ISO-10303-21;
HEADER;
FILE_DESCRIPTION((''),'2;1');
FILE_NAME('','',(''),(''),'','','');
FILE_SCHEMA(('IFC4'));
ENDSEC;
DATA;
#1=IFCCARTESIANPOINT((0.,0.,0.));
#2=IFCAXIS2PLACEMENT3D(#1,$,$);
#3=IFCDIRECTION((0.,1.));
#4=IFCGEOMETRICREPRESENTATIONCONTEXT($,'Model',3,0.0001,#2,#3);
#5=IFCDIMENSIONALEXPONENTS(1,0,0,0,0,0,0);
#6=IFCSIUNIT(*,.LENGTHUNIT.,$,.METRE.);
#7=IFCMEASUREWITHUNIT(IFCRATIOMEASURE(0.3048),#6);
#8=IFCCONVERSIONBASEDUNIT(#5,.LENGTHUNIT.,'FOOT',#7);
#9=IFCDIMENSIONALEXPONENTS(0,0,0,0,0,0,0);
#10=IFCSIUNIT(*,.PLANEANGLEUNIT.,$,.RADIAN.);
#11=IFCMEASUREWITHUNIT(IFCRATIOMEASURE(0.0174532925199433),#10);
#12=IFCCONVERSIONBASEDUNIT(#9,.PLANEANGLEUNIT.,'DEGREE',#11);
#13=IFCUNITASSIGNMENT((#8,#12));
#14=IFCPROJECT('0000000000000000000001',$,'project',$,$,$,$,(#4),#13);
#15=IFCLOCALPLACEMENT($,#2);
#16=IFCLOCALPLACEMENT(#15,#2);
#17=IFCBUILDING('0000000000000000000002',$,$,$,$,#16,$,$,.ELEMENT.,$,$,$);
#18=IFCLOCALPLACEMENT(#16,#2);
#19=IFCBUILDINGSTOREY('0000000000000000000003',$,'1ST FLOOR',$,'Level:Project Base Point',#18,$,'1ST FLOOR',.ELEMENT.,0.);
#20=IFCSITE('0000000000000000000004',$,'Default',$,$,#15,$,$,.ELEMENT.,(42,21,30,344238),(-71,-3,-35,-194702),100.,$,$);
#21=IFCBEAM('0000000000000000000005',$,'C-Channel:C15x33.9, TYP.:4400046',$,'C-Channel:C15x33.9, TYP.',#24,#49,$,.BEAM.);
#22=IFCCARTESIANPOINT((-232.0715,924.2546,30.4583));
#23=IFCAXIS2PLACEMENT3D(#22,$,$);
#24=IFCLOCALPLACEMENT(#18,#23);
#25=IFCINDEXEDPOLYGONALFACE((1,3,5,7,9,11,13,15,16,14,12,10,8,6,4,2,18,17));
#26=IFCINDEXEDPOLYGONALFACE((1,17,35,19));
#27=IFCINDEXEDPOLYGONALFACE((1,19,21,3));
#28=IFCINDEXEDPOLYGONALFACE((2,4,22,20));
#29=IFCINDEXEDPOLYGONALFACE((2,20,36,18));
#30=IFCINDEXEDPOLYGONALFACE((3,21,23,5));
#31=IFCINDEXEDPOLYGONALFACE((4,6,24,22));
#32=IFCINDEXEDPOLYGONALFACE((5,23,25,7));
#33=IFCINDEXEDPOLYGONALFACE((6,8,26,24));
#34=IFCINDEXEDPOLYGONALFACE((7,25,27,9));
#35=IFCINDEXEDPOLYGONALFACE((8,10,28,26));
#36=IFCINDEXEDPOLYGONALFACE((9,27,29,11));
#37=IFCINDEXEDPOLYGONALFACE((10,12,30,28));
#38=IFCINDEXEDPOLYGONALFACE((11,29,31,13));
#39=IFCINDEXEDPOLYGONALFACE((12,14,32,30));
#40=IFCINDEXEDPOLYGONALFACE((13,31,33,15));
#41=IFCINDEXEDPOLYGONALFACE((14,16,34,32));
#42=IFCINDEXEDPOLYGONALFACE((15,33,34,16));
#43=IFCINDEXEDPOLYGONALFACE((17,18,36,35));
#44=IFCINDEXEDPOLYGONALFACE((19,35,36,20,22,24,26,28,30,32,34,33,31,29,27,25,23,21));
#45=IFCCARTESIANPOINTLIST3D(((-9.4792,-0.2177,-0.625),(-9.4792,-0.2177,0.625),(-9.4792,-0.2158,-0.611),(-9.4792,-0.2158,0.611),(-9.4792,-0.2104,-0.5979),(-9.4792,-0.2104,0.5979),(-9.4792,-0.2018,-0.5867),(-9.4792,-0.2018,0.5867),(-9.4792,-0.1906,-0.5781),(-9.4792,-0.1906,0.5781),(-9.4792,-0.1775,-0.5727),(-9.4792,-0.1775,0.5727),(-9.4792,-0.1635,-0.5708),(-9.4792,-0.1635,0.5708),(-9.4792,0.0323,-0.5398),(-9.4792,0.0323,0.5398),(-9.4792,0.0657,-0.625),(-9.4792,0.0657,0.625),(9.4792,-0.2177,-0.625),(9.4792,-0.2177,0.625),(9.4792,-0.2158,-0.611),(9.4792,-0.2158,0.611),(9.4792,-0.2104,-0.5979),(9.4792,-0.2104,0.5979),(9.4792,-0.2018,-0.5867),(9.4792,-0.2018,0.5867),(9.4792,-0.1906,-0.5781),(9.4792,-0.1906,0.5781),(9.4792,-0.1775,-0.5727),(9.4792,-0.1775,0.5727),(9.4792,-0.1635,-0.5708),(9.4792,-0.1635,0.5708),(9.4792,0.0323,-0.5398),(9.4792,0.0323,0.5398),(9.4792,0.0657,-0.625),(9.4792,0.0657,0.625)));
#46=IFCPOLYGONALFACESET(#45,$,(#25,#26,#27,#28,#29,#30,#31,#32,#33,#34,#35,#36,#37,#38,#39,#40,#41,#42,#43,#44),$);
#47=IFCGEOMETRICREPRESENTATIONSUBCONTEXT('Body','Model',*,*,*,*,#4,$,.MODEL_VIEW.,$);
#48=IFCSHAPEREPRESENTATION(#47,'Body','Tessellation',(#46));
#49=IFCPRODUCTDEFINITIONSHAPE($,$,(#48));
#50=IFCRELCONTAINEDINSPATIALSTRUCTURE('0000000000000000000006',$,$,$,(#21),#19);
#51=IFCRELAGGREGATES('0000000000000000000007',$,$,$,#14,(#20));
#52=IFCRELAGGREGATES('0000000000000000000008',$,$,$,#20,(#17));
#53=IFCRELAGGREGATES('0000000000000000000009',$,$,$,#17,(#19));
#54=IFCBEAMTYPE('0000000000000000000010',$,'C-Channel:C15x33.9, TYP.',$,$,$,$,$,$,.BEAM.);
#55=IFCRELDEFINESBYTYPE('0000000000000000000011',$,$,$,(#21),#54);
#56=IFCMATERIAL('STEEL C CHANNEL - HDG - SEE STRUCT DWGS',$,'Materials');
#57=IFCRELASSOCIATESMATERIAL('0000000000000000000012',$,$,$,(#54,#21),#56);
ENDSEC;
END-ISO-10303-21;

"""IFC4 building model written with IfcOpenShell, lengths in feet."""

from ifc_helpers import new_model, entity, si_unit, converted_unit, direction, frame, frame_2d, origin, place, context, subcontext, project, spatial, polyline, circle_curve, parameter, trimmed, segment, composite_curve, outline, extrude, source, transform, mapped, material, material_profile, profile_set, profile_usage, type_object, type_shapes, element, save


model = new_model("IFC4")

# Units and contexts
model_context = context("Model", 3, precision=0.0001, world=origin(), true_north=direction((0.0, 1.0)))
body_context = subcontext(model_context, "Body", "Model", "MODEL_VIEW")
ifc_project = project(units=[converted_unit("LENGTHUNIT", "FOOT", entity("IfcRatioMeasure", 0.3048), si_unit("LENGTHUNIT", "METRE"), dimensions=[1, 0, 0, 0, 0, 0, 0]), converted_unit("PLANEANGLEUNIT", "DEGREE", entity("IfcRatioMeasure", 0.0174532925199433), si_unit("PLANEANGLEUNIT", "RADIAN"), dimensions=[0, 0, 0, 0, 0, 0, 0])], contexts=[model_context])

# Site, building, storey
site_placement = place(None, origin())
site = spatial("IfcSite", under=ifc_project, at=site_placement, Name="Default", CompositionType="ELEMENT", RefLatitude=(42, 21, 30, 344238), RefLongitude=(-71, -3, -35, -194702), RefElevation=100.0)
building_placement = place(site_placement, origin())
building = spatial("IfcBuilding", under=site, at=building_placement, CompositionType="ELEMENT")
storey_placement = place(building_placement, origin())
storey = spatial("IfcBuildingStorey", under=building, at=storey_placement, Name="1ST FLOOR", ObjectType="Level:Project Base Point", LongName="1ST FLOOR", CompositionType="ELEMENT", Elevation=0.0)

# Beam
ifc_material_1 = material(Name="STEEL C CHANNEL - HDG - SEE STRUCT DWGS", Category="Materials")
ifc_material_profile_1 = material_profile(ifc_material_1, outline(composite_curve([segment(polyline([(0.0323, -0.5398, 0.0), (0.0323, 0.5398, 0.0)]), True, "CONTINUOUS"), segment(polyline([(0.0323, 0.5398, 0.0), (-0.1635, 0.5708, 0.0)]), True, "CONTINUOUS"), segment(trimmed(circle_curve(frame((-0.1635, 0.625, 0.0), z_axis=(0.0, 0.0, -1.0), x_axis=(-1.0, 0.0, 0.0)), 0.0542), [parameter(270.0)], [parameter(360.0)], True, "PARAMETER"), True, "CONTINUOUS"), segment(polyline([(-0.2177, 0.625, 0.0), (0.0657, 0.625, 0.0)]), True, "CONTINUOUS"), segment(polyline([(0.0657, 0.625, 0.0), (0.0657, -0.625, 0.0)]), True, "CONTINUOUS"), segment(polyline([(0.0657, -0.625, 0.0), (-0.2177, -0.625, 0.0)]), True, "CONTINUOUS"), segment(trimmed(circle_curve(frame((-0.1635, -0.625, 0.0), z_axis=(0.0, 0.0, -1.0), x_axis=(-1.0, 0.0, 0.0)), 0.0542), [parameter(0.0)], [parameter(90.0)], True, "PARAMETER"), True, "CONTINUOUS"), segment(polyline([(-0.1635, -0.5708, 0.0), (0.0323, -0.5398, 0.0)]), True, "CONTINUOUS")], self_intersect=False), kind="CURVE"), Name="C15x33.9, TYP.")
ifc_profile_set_1 = profile_set([ifc_material_profile_1], Name="C15x33.9, TYP.")
ifc_profile_usage_1 = profile_usage(ifc_profile_set_1, cardinal=8)
beam_type_1 = type_object("IfcBeamType", Name="C-Channel:C15x33.9, TYP.", PredefinedType="BEAM", material=ifc_profile_set_1)
shared_shape_1 = source(origin(), body_context, "Body", "SweptSolid", [
    extrude(outline(composite_curve([segment(polyline([(-0.1469, -0.625), (0.1365, -0.625)]), True, "CONTINUOUS"), segment(polyline([(0.1365, -0.625), (0.1365, 0.625)]), True, "CONTINUOUS"), segment(polyline([(0.1365, 0.625), (-0.1469, 0.625)]), True, "CONTINUOUS"), segment(trimmed(circle_curve(frame_2d((-0.0927, 0.625), x_axis=(-1.0, 0.0)), 0.0542), [parameter(0.0)], [parameter(90.0)], True, "PARAMETER"), True, "CONTINUOUS"), segment(polyline([(-0.0927, 0.5708), (0.1031, 0.5398)]), True, "CONTINUOUS"), segment(polyline([(0.1031, 0.5398), (0.1031, -0.5398)]), True, "CONTINUOUS"), segment(polyline([(0.1031, -0.5398), (-0.0927, -0.5708)]), True, "CONTINUOUS"), segment(trimmed(circle_curve(frame_2d((-0.0927, -0.625), x_axis=(0.0, 1.0)), 0.0542), [parameter(0.0)], [parameter(90.0)], True, "PARAMETER"), True, "CONTINUOUS")], self_intersect=False)), frame((-9.4792, -0.0708, 0.0), z_axis=(1.0, 0.0, 0.0), x_axis=(0.0, 1.0, 0.0)), (0.0, 0.0, 1.0), 18.9583),
])
type_shapes(beam_type_1, [shared_shape_1])
beam_1_placement = place(storey_placement, frame((-232.0715, 924.2546, 30.4583)))
element("IfcBeam", 1, at=beam_1_placement, inside=storey, type_object=beam_type_1, material=ifc_profile_usage_1, Name="C-Channel:C15x33.9, TYP.:4400046", ObjectType="C-Channel:C15x33.9, TYP.", PredefinedType="BEAM", context=body_context, shape_type="MappedRepresentation", body=[
    mapped(shared_shape_1, transform((0.0, 0.0, 0.0), scale=1.0)),
])

save(model, "model.ifc")
